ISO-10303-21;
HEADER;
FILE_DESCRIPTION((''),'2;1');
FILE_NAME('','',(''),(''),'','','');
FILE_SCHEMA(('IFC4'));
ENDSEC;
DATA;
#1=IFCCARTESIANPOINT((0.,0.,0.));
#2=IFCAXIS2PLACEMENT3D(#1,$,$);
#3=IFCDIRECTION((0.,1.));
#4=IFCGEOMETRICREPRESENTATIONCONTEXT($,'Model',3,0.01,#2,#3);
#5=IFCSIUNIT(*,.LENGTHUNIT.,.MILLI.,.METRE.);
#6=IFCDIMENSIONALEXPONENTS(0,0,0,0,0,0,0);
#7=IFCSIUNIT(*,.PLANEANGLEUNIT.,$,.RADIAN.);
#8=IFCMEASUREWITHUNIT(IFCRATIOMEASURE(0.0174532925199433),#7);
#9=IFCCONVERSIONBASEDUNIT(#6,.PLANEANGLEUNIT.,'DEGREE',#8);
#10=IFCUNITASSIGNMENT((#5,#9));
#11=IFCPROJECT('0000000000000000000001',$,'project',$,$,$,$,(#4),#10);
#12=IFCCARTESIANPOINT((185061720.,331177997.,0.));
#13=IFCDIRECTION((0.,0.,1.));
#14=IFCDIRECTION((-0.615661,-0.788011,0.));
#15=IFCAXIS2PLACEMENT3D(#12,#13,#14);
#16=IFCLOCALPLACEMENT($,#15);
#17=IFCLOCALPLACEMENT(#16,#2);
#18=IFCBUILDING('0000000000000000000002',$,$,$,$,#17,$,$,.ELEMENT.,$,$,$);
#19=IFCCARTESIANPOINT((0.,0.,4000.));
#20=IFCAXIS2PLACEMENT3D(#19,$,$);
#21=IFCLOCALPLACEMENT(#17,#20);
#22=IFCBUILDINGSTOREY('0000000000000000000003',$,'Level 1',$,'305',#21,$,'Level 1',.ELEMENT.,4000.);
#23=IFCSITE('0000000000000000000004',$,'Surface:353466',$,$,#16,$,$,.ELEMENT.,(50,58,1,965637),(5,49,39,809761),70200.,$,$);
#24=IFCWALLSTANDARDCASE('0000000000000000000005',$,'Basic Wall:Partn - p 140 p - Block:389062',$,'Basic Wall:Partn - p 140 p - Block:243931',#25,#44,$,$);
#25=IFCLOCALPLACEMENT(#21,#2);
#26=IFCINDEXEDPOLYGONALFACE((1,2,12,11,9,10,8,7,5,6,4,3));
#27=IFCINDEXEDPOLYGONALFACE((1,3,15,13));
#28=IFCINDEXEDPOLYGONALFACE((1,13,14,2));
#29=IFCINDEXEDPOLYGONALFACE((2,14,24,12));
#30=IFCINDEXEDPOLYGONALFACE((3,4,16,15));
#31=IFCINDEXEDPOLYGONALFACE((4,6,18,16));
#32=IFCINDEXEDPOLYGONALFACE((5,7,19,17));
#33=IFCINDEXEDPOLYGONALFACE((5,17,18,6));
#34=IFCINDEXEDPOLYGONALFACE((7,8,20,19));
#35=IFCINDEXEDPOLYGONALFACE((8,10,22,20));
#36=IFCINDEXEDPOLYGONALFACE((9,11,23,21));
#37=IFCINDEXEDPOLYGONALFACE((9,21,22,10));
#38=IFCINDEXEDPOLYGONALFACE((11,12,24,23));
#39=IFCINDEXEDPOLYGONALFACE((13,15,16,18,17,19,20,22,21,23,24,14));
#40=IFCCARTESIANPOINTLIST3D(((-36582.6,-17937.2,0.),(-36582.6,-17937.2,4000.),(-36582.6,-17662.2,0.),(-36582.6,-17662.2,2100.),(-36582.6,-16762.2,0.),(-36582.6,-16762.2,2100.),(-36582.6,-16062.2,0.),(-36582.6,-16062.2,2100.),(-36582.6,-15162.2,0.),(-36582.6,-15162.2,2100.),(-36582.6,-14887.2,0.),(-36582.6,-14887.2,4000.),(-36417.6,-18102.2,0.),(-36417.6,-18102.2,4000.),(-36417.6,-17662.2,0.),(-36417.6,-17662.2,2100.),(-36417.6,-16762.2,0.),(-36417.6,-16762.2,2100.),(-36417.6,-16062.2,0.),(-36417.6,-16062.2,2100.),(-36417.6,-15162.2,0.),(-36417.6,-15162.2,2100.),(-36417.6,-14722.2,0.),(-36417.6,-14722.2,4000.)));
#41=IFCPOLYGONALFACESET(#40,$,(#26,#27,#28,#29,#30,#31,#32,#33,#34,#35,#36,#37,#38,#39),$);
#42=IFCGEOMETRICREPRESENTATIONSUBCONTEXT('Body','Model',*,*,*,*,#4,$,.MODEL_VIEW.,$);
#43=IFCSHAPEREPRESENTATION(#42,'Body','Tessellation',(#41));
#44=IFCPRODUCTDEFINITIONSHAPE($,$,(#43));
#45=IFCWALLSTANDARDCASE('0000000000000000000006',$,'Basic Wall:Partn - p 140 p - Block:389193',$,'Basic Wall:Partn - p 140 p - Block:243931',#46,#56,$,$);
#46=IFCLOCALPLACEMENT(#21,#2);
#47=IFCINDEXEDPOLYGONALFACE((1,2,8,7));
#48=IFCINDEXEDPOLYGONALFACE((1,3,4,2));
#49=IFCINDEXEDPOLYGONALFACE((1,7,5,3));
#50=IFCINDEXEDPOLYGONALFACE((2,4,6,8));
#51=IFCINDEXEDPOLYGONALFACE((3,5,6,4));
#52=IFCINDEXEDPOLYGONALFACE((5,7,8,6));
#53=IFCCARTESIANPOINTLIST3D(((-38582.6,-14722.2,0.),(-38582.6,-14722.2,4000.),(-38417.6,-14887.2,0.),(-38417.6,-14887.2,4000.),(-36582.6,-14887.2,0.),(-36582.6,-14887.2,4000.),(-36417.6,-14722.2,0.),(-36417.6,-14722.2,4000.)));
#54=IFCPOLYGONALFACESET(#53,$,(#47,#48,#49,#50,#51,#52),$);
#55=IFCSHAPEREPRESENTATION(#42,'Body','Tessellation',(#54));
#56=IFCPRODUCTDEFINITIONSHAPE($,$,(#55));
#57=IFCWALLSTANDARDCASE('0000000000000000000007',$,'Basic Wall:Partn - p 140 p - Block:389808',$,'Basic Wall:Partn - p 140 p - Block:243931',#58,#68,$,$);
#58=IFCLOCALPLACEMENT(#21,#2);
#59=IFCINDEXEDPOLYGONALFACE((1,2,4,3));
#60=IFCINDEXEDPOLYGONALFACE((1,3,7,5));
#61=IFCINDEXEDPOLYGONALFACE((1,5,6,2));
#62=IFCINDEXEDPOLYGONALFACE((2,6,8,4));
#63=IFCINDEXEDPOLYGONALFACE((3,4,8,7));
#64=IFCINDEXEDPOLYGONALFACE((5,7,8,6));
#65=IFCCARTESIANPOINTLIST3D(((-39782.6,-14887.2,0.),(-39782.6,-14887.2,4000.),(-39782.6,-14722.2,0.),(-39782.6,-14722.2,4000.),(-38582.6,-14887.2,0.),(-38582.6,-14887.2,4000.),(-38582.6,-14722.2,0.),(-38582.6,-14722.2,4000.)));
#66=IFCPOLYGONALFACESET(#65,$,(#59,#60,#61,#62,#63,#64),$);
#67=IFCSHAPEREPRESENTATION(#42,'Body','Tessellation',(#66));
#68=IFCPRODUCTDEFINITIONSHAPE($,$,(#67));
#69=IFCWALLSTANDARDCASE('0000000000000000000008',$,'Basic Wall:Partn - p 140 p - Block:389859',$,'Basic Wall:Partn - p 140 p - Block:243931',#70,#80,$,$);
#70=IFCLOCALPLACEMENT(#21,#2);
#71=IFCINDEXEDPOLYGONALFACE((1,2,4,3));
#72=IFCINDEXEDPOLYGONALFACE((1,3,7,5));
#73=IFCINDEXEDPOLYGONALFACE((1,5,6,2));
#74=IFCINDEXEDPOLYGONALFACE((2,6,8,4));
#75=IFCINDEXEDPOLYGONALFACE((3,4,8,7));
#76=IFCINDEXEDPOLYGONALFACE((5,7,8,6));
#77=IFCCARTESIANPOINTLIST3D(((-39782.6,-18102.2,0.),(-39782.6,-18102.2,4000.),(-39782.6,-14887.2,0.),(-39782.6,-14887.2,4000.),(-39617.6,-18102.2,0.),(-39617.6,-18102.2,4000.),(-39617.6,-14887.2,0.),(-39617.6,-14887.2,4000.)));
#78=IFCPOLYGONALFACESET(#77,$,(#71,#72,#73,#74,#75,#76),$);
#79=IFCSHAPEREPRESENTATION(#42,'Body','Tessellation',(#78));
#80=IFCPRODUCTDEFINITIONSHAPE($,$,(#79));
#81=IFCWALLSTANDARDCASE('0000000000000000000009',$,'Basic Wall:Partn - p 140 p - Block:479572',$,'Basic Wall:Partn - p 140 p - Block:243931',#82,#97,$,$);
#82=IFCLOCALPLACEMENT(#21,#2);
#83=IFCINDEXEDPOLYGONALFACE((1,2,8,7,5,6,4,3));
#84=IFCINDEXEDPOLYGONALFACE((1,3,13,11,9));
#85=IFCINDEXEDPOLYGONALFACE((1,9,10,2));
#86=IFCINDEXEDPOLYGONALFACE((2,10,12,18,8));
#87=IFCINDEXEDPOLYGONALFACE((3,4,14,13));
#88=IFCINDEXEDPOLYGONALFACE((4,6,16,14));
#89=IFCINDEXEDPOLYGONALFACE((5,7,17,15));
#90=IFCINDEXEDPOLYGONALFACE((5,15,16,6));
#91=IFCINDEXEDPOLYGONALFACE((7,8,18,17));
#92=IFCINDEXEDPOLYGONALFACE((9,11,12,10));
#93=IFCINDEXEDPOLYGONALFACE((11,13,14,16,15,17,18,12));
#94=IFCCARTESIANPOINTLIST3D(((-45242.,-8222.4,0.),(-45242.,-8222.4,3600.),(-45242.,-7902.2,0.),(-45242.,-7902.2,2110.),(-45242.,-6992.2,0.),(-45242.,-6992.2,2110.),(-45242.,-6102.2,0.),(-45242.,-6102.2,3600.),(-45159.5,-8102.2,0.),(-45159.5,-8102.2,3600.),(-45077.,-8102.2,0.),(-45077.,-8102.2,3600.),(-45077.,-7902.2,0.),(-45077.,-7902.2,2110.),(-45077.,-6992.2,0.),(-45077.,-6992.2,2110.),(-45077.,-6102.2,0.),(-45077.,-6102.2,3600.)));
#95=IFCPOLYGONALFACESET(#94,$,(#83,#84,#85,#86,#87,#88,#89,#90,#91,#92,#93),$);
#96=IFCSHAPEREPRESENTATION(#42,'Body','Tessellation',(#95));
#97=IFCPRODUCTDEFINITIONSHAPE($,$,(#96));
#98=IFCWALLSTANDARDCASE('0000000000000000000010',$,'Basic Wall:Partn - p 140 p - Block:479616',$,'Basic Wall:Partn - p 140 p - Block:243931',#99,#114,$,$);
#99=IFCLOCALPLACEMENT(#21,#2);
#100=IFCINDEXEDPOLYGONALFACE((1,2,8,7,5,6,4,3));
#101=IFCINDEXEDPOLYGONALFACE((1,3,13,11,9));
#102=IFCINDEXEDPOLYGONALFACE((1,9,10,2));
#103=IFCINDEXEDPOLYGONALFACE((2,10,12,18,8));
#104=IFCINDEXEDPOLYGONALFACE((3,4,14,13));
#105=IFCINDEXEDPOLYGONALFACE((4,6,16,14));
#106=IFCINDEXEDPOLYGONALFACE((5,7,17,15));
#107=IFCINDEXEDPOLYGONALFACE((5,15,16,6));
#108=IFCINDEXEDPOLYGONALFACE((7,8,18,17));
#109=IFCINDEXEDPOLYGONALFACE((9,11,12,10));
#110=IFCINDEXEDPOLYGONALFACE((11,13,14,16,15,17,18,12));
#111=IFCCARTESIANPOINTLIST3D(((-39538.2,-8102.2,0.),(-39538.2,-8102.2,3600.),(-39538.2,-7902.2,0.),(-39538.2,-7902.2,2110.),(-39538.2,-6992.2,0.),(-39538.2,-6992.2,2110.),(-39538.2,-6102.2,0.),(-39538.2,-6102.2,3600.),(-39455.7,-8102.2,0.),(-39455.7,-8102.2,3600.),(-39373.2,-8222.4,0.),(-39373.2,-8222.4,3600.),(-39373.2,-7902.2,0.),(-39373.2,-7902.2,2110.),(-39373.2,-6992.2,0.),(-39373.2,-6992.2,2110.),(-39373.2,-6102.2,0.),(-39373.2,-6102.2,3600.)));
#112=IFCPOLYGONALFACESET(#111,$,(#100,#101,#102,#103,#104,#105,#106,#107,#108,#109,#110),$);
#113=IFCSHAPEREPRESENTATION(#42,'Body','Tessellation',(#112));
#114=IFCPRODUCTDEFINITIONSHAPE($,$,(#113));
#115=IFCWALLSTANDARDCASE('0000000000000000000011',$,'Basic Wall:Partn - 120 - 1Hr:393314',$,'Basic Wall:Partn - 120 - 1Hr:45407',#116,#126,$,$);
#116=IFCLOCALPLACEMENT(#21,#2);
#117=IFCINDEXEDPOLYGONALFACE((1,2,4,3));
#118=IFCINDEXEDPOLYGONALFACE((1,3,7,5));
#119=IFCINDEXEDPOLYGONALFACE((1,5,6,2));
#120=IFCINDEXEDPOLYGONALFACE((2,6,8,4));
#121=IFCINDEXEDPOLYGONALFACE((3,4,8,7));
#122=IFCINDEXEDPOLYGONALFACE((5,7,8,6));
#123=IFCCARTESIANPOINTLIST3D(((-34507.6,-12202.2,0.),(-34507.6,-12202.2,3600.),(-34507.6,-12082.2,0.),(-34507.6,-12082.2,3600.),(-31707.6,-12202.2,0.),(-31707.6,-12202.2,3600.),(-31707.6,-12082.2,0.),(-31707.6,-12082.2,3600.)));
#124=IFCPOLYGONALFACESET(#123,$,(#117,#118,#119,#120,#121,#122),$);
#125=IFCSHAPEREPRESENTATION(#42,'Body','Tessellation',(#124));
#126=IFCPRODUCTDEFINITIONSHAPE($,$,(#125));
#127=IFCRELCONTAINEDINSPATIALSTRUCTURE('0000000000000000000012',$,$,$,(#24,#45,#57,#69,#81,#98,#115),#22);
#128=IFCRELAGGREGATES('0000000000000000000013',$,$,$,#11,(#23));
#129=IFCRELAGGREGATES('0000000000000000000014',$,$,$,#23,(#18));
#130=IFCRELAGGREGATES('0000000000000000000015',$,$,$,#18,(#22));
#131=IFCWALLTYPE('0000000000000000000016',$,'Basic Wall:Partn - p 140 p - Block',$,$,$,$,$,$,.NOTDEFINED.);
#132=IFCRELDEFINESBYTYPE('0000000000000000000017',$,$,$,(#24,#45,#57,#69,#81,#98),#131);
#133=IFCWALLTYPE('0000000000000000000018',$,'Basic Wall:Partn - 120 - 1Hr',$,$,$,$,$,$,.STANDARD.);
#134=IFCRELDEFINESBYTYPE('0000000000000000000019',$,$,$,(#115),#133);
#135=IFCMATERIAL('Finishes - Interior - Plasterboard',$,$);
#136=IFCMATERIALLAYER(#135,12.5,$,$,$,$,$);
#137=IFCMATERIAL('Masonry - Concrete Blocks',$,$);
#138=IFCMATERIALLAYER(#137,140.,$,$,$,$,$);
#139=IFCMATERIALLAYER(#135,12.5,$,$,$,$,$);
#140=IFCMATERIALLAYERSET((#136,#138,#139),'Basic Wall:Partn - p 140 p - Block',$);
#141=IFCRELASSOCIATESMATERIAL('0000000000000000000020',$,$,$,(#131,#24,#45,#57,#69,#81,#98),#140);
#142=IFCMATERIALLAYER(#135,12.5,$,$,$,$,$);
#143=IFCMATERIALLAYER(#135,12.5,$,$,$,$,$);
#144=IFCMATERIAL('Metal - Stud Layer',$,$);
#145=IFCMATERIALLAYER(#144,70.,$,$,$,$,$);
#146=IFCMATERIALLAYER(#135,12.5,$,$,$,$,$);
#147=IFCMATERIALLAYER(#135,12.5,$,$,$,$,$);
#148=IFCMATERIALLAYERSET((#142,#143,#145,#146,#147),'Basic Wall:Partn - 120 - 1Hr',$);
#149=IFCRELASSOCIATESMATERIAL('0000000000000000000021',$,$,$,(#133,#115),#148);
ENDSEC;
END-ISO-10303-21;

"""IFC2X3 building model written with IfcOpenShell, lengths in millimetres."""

from ifc_helpers import new_model, entity, si_unit, converted_unit, direction, frame, frame_2d, origin, place, context, subcontext, project, spatial, polyline, rectangle, outline, extrude, clip, halfspace, bounded_halfspace, material, layer, layer_set, layer_usage, type_object, element, save


model = new_model("IFC2X3")

# Units and contexts
model_context = context("Model", 3, precision=0.01, world=origin(), true_north=direction((0.0, 1.0)))
body_context = subcontext(model_context, "Body", "Model", "MODEL_VIEW")
ifc_project = project(units=[si_unit("LENGTHUNIT", "METRE", prefix="MILLI"), converted_unit("PLANEANGLEUNIT", "DEGREE", entity("IfcRatioMeasure", 0.0174532925199433), si_unit("PLANEANGLEUNIT", "RADIAN"), dimensions=[0, 0, 0, 0, 0, 0, 0])], contexts=[model_context])

# Site, building, storey
site_placement = place(None, frame((185061720.0, 331177997.0, 0.0), z_axis=(0.0, 0.0, 1.0), x_axis=(-0.615661, -0.788011, 0.0)))
site = spatial("IfcSite", under=ifc_project, at=site_placement, Name="Surface:353466", CompositionType="ELEMENT", RefLatitude=(50, 58, 1, 965637), RefLongitude=(5, 49, 39, 809761), RefElevation=70200.0)
building_placement = place(site_placement, origin())
building = spatial("IfcBuilding", under=site, at=building_placement, CompositionType="ELEMENT")
storey_placement = place(building_placement, frame((0.0, 0.0, 4000.0)))
storey = spatial("IfcBuildingStorey", under=building, at=storey_placement, Name="Level 1", ObjectType="305", LongName="Level 1", CompositionType="ELEMENT", Elevation=4000.0)

# Wall, openings
ifc_material_1 = material(Name="Finishes - Interior - Plasterboard")
ifc_layer_1 = layer(ifc_material_1, 12.5)
ifc_material_2 = material(Name="Masonry - Concrete Blocks")
ifc_layer_2 = layer(ifc_material_2, 140.0)
ifc_layer_3 = layer(ifc_material_1, 12.5)
ifc_layer_set_1 = layer_set([ifc_layer_1, ifc_layer_2, ifc_layer_3], Name="Basic Wall:Partn - p 140 p - Block")
ifc_layer_usage_1 = layer_usage(ifc_layer_set_1, "AXIS2", "NEGATIVE", 82.5)
wall_type_1 = type_object("IfcWallType", Name="Basic Wall:Partn - p 140 p - Block", PredefinedType="NOTDEFINED", material=ifc_layer_set_1)
wall_1_placement = place(storey_placement, frame((-36500.1, -14722.2, 0.0), z_axis=(0.0, 0.0, 1.0), x_axis=(0.0, -1.0, 0.0)))
wall_1 = element("IfcWallStandardCase", 1, at=wall_1_placement, inside=storey, type_object=wall_type_1, material=ifc_layer_usage_1, Name="Basic Wall:Partn - p 140 p - Block:389062", ObjectType="Basic Wall:Partn - p 140 p - Block:243931", context=body_context, shape_type="Clipping", body=[
    clip(extrude(outline(polyline([(3215.0, -82.5), (3380.0, 82.5), (0.0, 82.5), (165.0, -82.5), (3215.0, -82.5)])), origin(), (0.0, 0.0, 1.0), 4000.0), halfspace(frame((0.0, 0.0, -4000.0)), True)),
])
opening_1_placement = place(wall_1_placement, frame((1340.0, -1606.5, 0.0)))
element("IfcOpeningElement", 2, at=opening_1_placement, cuts=wall_1, ObjectType="Opening", context=body_context, shape_type="SweptSolid", body=[
    extrude(rectangle(XDim=2100.0, YDim=900.0, at=frame_2d((0.0, 0.0), x_axis=(0.0, 1.0))), frame((-450.0, 0.0, 1050.0), z_axis=(0.0, 1.0, 0.0), x_axis=(-1.0, 0.0, 0.0)), (0.0, 0.0, 1.0), 3048.0),
])
opening_2_placement = place(wall_1_placement, frame((1340.0, -1606.5, 4000.0)))
element("IfcOpeningElement", 3, at=opening_2_placement, cuts=wall_1, ObjectType="Opening", context=body_context, shape_type="SweptSolid", body=[
    extrude(rectangle(XDim=2100.0, YDim=900.0, at=frame_2d((0.0, 0.0), x_axis=(0.0, 1.0))), frame((-450.0, 0.0, 1050.0), z_axis=(0.0, 1.0, 0.0), x_axis=(-1.0, 0.0, 0.0)), (0.0, 0.0, 1.0), 3048.0),
])
opening_3_placement = place(wall_1_placement, frame((2940.0, -1606.5, 0.0)))
element("IfcOpeningElement", 4, at=opening_3_placement, cuts=wall_1, ObjectType="Opening", context=body_context, shape_type="SweptSolid", body=[
    extrude(rectangle(XDim=2100.0, YDim=900.0, at=frame_2d((0.0, 0.0), x_axis=(0.0, 1.0))), frame((-450.0, 0.0, 1050.0), z_axis=(0.0, 1.0, 0.0), x_axis=(-1.0, 0.0, 0.0)), (0.0, 0.0, 1.0), 3048.0),
])
opening_4_placement = place(wall_1_placement, frame((2940.0, -1606.5, 4000.0)))
element("IfcOpeningElement", 5, at=opening_4_placement, cuts=wall_1, ObjectType="Opening", context=body_context, shape_type="SweptSolid", body=[
    extrude(rectangle(XDim=2100.0, YDim=900.0, at=frame_2d((0.0, 0.0), x_axis=(0.0, 1.0))), frame((-450.0, 0.0, 1050.0), z_axis=(0.0, 1.0, 0.0), x_axis=(-1.0, 0.0, 0.0)), (0.0, 0.0, 1.0), 3048.0),
])

# Walls
ifc_layer_usage_2 = layer_usage(ifc_layer_set_1, "AXIS2", "NEGATIVE", 82.5)
wall_2_placement = place(storey_placement, frame((-38582.6, -14804.7, 0.0)))
element("IfcWallStandardCase", 6, at=wall_2_placement, inside=storey, type_object=wall_type_1, material=ifc_layer_usage_2, Name="Basic Wall:Partn - p 140 p - Block:389193", ObjectType="Basic Wall:Partn - p 140 p - Block:243931", context=body_context, shape_type="Clipping", body=[
    clip(extrude(outline(polyline([(2000.0, -82.5), (2165.0, 82.5), (0.0, 82.5), (165.0, -82.5), (2000.0, -82.5)])), origin(), (0.0, 0.0, 1.0), 4000.0), halfspace(frame((0.0, 0.0, -4000.0)), True)),
])
ifc_layer_usage_3 = layer_usage(ifc_layer_set_1, "AXIS2", "POSITIVE", -82.5)
wall_3_placement = place(storey_placement, frame((-38582.6, -14804.7, 0.0), z_axis=(0.0, 0.0, 1.0), x_axis=(-1.0, 0.0, 0.0)))
element("IfcWallStandardCase", 7, at=wall_3_placement, inside=storey, type_object=wall_type_1, material=ifc_layer_usage_3, Name="Basic Wall:Partn - p 140 p - Block:389808", ObjectType="Basic Wall:Partn - p 140 p - Block:243931", context=body_context, shape_type="Clipping", body=[
    clip(extrude(rectangle(XDim=1200.0, YDim=165.0, at=frame_2d((600.0, 0.0), x_axis=(-1.0, 0.0))), origin(), (0.0, 0.0, 1.0), 4000.0), halfspace(origin(), True)),
])
ifc_layer_usage_4 = layer_usage(ifc_layer_set_1, "AXIS2", "POSITIVE", -82.5)
wall_4_placement = place(storey_placement, frame((-39700.1, -14887.2, 0.0), z_axis=(0.0, 0.0, 1.0), x_axis=(0.0, -1.0, 0.0)))
element("IfcWallStandardCase", 8, at=wall_4_placement, inside=storey, type_object=wall_type_1, material=ifc_layer_usage_4, Name="Basic Wall:Partn - p 140 p - Block:389859", ObjectType="Basic Wall:Partn - p 140 p - Block:243931", context=body_context, shape_type="Clipping", body=[
    clip(extrude(rectangle(XDim=3215.0, YDim=165.0, at=frame_2d((1607.5, 0.0), x_axis=(-1.0, 0.0))), origin(), (0.0, 0.0, 1.0), 4000.0), halfspace(origin(), True)),
])

# Walls, openings
ifc_layer_usage_5 = layer_usage(ifc_layer_set_1, "AXIS2", "NEGATIVE", 82.5)
wall_5_placement = place(storey_placement, frame((-45159.5, -8222.4, 0.0), z_axis=(0.0, 0.0, 1.0), x_axis=(0.0, 1.0, 0.0)))
wall_5 = element("IfcWallStandardCase", 9, at=wall_5_placement, inside=storey, type_object=wall_type_1, material=ifc_layer_usage_5, Name="Basic Wall:Partn - p 140 p - Block:479572", ObjectType="Basic Wall:Partn - p 140 p - Block:243931", context=body_context, shape_type="Clipping", body=[
    clip(extrude(outline(polyline([(120.1, -82.5), (2120.1, -82.5), (2120.1, 82.5), (0.0, 82.5), (120.1, 0.0), (120.1, -82.5)])), origin(), (0.0, 0.0, 1.0), 3600.0), bounded_halfspace(frame((120.1, -82.5, 3600.0), z_axis=(0.0, 0.0, -1.0), x_axis=(0.0, -1.0, 0.0)), True, frame((120.1, -82.5, 3600.0)), polyline([(0.0, 0.0), (2000.0, 0.0), (2000.0, 165.0), (-120.1, 165.0), (0.0, 82.5), (0.0, 0.0)]))),
])
opening_5_placement = place(wall_5_placement, frame((320.1, 1606.5, 0.0)))
element("IfcOpeningElement", 10, at=opening_5_placement, cuts=wall_5, ObjectType="Opening", context=body_context, shape_type="SweptSolid", body=[
    extrude(rectangle(XDim=2110.0, YDim=910.0, at=frame_2d((0.0, 0.0), x_axis=(1.0, 0.0))), frame((455.0, -3048.0, 1055.0), z_axis=(0.0, 1.0, 0.0), x_axis=(0.0, 0.0, 1.0)), (0.0, 0.0, 1.0), 3048.0),
])
opening_6_placement = place(wall_5_placement, frame((1230.1, 82.5, 0.0)))
element("IfcOpeningElement", 11, at=opening_6_placement, cuts=wall_5, ObjectType="Opening", context=body_context, shape_type="SweptSolid", body=[
    extrude(rectangle(XDim=2110.0, YDim=910.0, at=frame_2d((1055.0, 455.0), x_axis=(1.0, 0.0))), frame((0.0, 0.0, 0.0), z_axis=(0.0, -1.0, 0.0), x_axis=(0.0, 0.0, 1.0)), (0.0, 0.0, 1.0), 165.0),
])
ifc_layer_usage_6 = layer_usage(ifc_layer_set_1, "AXIS2", "NEGATIVE", 82.5)
wall_6_placement = place(storey_placement, frame((-39455.7, -8222.4, 0.0), z_axis=(0.0, 0.0, 1.0), x_axis=(0.0, 1.0, 0.0)))
wall_6 = element("IfcWallStandardCase", 12, at=wall_6_placement, inside=storey, type_object=wall_type_1, material=ifc_layer_usage_6, Name="Basic Wall:Partn - p 140 p - Block:479616", ObjectType="Basic Wall:Partn - p 140 p - Block:243931", context=body_context, shape_type="Clipping", body=[
    clip(extrude(outline(polyline([(0.0, -82.5), (2120.1, -82.5), (2120.1, 82.5), (120.1, 82.5), (120.1, 0.0), (0.0, -82.5)])), origin(), (0.0, 0.0, 1.0), 3600.0), bounded_halfspace(frame((0.0, -82.5, 3600.0), z_axis=(0.0, 0.0, -1.0), x_axis=(0.0, -1.0, 0.0)), True, frame((0.0, -82.5, 3600.0)), polyline([(0.0, 0.0), (2120.1, 0.0), (2120.1, 165.0), (120.1, 165.0), (120.1, 82.5), (0.0, 0.0)]))),
])
opening_7_placement = place(wall_6_placement, frame((320.1, 1441.5, 0.0)))
element("IfcOpeningElement", 13, at=opening_7_placement, cuts=wall_6, ObjectType="Opening", context=body_context, shape_type="SweptSolid", body=[
    extrude(rectangle(XDim=2110.0, YDim=910.0, at=frame_2d((0.0, 0.0), x_axis=(1.0, 0.0))), frame((455.0, -3048.0, 1055.0), z_axis=(0.0, 1.0, 0.0), x_axis=(0.0, 0.0, 1.0)), (0.0, 0.0, 1.0), 3048.0),
])
opening_8_placement = place(wall_6_placement, frame((320.1, -82.5, 0.0)))
element("IfcOpeningElement", 14, at=opening_8_placement, cuts=wall_6, ObjectType="Opening", context=body_context, shape_type="SweptSolid", body=[
    extrude(rectangle(XDim=2110.0, YDim=910.0, at=frame_2d((1055.0, 455.0), x_axis=(1.0, 0.0))), frame((0.0, 0.0, 0.0), z_axis=(0.0, 1.0, 0.0), x_axis=(0.0, 0.0, 1.0)), (0.0, 0.0, 1.0), 165.0),
])

# Wall
ifc_layer_4 = layer(ifc_material_1, 12.5)
ifc_layer_5 = layer(ifc_material_1, 12.5)
ifc_material_3 = material(Name="Metal - Stud Layer")
ifc_layer_6 = layer(ifc_material_3, 70.0)
ifc_layer_7 = layer(ifc_material_1, 12.5)
ifc_layer_8 = layer(ifc_material_1, 12.5)
ifc_layer_set_2 = layer_set([ifc_layer_4, ifc_layer_5, ifc_layer_6, ifc_layer_7, ifc_layer_8], Name="Basic Wall:Partn - 120 - 1Hr")
ifc_layer_usage_7 = layer_usage(ifc_layer_set_2, "AXIS2", "NEGATIVE", 60.0)
wall_type_2 = type_object("IfcWallType", Name="Basic Wall:Partn - 120 - 1Hr", PredefinedType="STANDARD", material=ifc_layer_set_2)
wall_7_placement = place(storey_placement, frame((-34507.6, -12142.2, 0.0)))
element("IfcWallStandardCase", 15, at=wall_7_placement, inside=storey, type_object=wall_type_2, material=ifc_layer_usage_7, Name="Basic Wall:Partn - 120 - 1Hr:393314", ObjectType="Basic Wall:Partn - 120 - 1Hr:45407", context=body_context, shape_type="Clipping", body=[
    clip(extrude(rectangle(XDim=2800.0, YDim=120.0, at=frame_2d((1400.0, 0.0), x_axis=(-1.0, 0.0))), origin(), (0.0, 0.0, 1.0), 3600.0), bounded_halfspace(frame((0.0, -60.0, 3600.0), z_axis=(0.0, 0.0, -1.0), x_axis=(1.0, 0.0, 0.0)), True, frame((0.0, -60.0, 3600.0)), polyline([(0.0, 0.0), (2800.0, 0.0), (2800.0, 120.0), (120.0, 120.0), (0.0, 120.0), (0.0, 0.0)]))),
])

save(model, "model.ifc")
